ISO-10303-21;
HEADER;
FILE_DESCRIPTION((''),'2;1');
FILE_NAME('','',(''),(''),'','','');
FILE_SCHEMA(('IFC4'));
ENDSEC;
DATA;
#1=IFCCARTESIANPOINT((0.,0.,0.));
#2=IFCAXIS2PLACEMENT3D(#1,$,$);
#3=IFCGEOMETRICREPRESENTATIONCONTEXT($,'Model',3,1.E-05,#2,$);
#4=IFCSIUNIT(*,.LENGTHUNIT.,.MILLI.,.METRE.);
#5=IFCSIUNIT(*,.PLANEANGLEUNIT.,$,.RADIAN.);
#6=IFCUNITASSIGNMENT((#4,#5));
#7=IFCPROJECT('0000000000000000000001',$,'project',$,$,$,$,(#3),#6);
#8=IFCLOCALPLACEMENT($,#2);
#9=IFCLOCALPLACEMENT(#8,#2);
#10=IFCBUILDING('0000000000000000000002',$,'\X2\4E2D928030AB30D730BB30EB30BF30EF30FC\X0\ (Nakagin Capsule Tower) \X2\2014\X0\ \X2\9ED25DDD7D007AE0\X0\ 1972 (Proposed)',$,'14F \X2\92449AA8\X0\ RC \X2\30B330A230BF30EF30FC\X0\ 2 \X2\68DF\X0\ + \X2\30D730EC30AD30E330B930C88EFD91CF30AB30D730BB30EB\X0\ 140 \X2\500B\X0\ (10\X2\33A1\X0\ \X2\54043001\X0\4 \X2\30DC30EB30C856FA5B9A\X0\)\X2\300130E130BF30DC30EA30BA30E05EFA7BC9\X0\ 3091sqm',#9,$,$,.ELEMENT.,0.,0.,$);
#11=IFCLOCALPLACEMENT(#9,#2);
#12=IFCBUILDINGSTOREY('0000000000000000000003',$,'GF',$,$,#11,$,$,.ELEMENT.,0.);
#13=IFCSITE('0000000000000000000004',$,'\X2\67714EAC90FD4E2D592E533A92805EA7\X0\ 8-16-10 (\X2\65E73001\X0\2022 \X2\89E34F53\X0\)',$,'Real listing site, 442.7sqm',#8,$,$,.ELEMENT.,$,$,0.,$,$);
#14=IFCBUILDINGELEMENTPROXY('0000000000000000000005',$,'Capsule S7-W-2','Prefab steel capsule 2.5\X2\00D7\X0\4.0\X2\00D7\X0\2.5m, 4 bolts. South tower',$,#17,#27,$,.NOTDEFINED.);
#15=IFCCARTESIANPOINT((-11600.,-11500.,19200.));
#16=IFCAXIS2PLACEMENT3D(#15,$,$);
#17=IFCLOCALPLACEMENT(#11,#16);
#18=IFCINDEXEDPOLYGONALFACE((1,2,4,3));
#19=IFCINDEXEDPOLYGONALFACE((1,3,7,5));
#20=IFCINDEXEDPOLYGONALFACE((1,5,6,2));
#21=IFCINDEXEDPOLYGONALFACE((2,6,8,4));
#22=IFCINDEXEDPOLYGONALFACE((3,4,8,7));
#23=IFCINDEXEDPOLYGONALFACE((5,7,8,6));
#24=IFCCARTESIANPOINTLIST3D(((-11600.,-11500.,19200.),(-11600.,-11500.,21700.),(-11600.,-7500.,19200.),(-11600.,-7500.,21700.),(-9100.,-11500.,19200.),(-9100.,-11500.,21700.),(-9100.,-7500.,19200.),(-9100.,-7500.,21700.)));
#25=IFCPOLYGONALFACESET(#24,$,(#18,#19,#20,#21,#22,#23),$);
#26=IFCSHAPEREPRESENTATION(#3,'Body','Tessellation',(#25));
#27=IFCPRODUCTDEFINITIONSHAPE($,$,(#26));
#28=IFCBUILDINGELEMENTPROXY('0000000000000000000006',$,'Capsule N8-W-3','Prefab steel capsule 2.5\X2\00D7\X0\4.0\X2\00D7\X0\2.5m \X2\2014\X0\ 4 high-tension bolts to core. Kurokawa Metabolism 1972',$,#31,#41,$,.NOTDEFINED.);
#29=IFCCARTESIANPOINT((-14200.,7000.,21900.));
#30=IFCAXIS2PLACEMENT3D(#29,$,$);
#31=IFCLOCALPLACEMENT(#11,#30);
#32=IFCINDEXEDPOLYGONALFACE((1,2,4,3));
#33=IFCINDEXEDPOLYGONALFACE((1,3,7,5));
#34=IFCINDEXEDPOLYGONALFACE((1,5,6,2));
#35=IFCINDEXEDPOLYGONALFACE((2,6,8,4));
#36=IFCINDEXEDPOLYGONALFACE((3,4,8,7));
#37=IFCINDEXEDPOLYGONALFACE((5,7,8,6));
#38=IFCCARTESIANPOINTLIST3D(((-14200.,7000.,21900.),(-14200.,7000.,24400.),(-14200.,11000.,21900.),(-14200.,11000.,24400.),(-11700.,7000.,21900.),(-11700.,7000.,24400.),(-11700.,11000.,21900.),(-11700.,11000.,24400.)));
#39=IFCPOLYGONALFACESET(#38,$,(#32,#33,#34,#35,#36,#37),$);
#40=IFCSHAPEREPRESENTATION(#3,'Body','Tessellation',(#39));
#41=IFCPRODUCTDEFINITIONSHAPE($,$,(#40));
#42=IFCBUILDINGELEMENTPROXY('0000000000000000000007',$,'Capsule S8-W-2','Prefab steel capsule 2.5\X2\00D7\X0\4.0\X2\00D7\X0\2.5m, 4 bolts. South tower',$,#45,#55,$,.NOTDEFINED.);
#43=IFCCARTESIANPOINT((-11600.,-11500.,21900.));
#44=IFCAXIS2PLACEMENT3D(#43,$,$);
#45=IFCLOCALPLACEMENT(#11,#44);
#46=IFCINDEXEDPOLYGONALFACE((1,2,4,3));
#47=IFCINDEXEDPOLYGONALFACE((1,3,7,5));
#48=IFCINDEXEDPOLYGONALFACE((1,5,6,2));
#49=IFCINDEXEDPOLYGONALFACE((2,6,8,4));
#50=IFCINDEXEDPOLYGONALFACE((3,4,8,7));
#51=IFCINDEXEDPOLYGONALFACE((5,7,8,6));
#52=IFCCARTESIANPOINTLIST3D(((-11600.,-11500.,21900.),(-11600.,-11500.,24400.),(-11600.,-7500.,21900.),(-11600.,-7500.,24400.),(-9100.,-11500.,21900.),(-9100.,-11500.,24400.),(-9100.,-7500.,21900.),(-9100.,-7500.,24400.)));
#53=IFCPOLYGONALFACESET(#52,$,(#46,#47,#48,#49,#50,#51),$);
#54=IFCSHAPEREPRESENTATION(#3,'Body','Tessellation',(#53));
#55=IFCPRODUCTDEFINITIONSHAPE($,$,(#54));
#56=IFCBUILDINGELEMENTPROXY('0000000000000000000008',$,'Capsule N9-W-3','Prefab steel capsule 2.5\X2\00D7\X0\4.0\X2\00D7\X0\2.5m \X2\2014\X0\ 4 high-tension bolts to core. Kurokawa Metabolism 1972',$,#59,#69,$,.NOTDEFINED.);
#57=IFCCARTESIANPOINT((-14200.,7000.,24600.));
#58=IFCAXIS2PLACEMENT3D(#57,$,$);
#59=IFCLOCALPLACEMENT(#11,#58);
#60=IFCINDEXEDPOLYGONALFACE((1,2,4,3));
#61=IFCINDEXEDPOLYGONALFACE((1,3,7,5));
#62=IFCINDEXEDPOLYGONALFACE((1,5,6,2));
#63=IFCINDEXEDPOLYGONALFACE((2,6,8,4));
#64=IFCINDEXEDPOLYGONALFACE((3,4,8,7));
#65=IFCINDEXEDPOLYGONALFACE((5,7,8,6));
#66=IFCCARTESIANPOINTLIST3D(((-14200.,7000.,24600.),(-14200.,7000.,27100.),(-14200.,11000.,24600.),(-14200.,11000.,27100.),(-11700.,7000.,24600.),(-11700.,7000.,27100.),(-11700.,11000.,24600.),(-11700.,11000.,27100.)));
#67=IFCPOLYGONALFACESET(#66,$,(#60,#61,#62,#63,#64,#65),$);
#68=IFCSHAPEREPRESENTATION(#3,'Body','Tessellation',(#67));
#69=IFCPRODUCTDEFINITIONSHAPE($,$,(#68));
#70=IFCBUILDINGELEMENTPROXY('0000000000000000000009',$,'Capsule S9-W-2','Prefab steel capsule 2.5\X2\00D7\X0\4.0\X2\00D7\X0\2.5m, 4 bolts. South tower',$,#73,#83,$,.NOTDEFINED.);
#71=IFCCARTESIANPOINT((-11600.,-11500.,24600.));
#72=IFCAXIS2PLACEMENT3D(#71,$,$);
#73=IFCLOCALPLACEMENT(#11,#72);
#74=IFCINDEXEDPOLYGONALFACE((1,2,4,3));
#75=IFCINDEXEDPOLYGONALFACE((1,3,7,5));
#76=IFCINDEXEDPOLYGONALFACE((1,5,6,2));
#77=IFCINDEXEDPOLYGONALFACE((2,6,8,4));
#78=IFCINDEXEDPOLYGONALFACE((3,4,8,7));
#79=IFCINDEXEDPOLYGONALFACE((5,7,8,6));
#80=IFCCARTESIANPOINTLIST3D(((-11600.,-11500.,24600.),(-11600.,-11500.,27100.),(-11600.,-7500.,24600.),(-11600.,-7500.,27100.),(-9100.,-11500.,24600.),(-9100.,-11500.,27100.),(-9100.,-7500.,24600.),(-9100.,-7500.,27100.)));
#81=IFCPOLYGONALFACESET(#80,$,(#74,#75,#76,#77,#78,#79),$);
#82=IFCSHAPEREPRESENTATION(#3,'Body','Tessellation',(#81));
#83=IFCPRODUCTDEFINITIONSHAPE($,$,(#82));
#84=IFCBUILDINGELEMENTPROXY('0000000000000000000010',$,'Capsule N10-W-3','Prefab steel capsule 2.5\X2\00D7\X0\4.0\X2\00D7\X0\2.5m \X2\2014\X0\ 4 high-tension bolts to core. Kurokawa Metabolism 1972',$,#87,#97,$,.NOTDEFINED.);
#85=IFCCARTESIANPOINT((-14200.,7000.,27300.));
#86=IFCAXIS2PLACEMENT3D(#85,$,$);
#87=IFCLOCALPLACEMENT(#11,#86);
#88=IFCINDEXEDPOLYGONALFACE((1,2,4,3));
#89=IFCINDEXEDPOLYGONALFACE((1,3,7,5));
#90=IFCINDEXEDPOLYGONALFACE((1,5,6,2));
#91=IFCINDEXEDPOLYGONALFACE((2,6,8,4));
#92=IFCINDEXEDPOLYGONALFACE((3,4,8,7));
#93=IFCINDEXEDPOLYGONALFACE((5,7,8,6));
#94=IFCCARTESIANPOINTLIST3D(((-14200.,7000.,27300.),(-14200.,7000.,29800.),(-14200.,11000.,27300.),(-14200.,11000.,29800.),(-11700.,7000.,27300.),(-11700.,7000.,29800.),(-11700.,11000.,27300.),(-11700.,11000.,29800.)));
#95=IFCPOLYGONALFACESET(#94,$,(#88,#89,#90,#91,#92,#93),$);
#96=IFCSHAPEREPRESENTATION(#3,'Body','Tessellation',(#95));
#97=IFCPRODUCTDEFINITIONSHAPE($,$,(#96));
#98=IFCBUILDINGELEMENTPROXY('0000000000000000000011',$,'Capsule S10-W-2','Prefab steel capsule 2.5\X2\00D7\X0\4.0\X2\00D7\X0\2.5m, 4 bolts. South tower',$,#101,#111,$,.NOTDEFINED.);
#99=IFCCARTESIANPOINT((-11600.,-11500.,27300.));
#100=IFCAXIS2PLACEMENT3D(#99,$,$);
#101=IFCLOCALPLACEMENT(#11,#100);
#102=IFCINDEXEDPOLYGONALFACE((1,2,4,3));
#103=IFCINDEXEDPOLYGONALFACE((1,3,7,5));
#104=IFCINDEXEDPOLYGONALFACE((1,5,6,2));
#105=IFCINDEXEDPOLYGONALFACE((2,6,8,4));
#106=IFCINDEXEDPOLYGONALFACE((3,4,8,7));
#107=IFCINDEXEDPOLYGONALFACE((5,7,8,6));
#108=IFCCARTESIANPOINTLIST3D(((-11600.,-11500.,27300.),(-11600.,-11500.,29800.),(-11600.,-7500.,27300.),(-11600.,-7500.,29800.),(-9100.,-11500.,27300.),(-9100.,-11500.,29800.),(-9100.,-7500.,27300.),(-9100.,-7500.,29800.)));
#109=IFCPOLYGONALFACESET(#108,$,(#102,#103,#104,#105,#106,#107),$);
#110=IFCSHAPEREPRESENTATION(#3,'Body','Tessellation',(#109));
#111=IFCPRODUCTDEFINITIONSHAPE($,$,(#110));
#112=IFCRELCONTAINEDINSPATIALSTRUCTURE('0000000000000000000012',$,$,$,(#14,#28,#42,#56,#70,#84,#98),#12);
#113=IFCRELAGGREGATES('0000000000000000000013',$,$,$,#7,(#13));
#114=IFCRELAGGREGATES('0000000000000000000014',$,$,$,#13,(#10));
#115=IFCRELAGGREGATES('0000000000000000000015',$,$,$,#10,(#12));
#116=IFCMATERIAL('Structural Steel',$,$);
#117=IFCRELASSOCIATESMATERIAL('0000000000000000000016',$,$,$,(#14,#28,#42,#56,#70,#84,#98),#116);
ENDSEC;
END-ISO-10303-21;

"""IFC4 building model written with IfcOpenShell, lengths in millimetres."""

from ifc_helpers import new_model, si_unit, frame, frame_2d, origin, place, context, project, spatial, rectangle, extrude, material, element, save


model = new_model("IFC4")

# Units and contexts
model_context = context("Model", 3, precision=1e-05, world=origin())
ifc_project = project(units=[si_unit("LENGTHUNIT", "METRE", prefix="MILLI"), si_unit("PLANEANGLEUNIT", "RADIAN")], contexts=[model_context])

# Site, building, storey
site_placement = place(None, origin())
site = spatial("IfcSite", under=ifc_project, at=site_placement, Name="東京都中央区銀座 8-16-10 (旧、2022 解体)", ObjectType="Real listing site, 442.7sqm", CompositionType="ELEMENT", RefElevation=0.0)
building_placement = place(site_placement, origin())
building = spatial("IfcBuilding", under=site, at=building_placement, Name="中銀カプセルタワー (Nakagin Capsule Tower) — 黒川紀章 1972 (Proposed)", ObjectType="14F 鉄骨 RC コアタワー 2 棟 + プレキャスト軽量カプセル 140 個 (10㎡ 各、4 ボルト固定)、メタボリズム建築 3091sqm", CompositionType="ELEMENT", ElevationOfRefHeight=0.0, ElevationOfTerrain=0.0)
storey_placement = place(building_placement, origin())
storey = spatial("IfcBuildingStorey", under=building, at=storey_placement, Name="GF", CompositionType="ELEMENT", Elevation=0.0)

# Shared definitions
ifc_material_1 = material(Name="Structural Steel")

# Building element proxies
proxy_1_placement = place(storey_placement, frame((-11600.0, -11500.0, 19200.0)))
element("IfcBuildingElementProxy", 1, at=proxy_1_placement, inside=storey, material=ifc_material_1, Name="Capsule S7-W-2", Description="Prefab steel capsule 2.5×4.0×2.5m, 4 bolts. South tower", PredefinedType="NOTDEFINED", context=model_context, shape_type="SweptSolid", body=[
    extrude(rectangle(XDim=2500.0, YDim=4000.0, at=frame_2d((1250.0, 2000.0))), frame((-11600.0, -11500.0, 19200.0)), (0.0, 0.0, 1.0), 2500.0),
])
proxy_2_placement = place(storey_placement, frame((-14200.0, 7000.0, 21900.0)))
element("IfcBuildingElementProxy", 2, at=proxy_2_placement, inside=storey, material=ifc_material_1, Name="Capsule N8-W-3", Description="Prefab steel capsule 2.5×4.0×2.5m — 4 high-tension bolts to core. Kurokawa Metabolism 1972", PredefinedType="NOTDEFINED", context=model_context, shape_type="SweptSolid", body=[
    extrude(rectangle(XDim=2500.0, YDim=4000.0, at=frame_2d((1250.0, 2000.0))), frame((-14200.0, 7000.0, 21900.0)), (0.0, 0.0, 1.0), 2500.0),
])
proxy_3_placement = place(storey_placement, frame((-11600.0, -11500.0, 21900.0)))
element("IfcBuildingElementProxy", 3, at=proxy_3_placement, inside=storey, material=ifc_material_1, Name="Capsule S8-W-2", Description="Prefab steel capsule 2.5×4.0×2.5m, 4 bolts. South tower", PredefinedType="NOTDEFINED", context=model_context, shape_type="SweptSolid", body=[
    extrude(rectangle(XDim=2500.0, YDim=4000.0, at=frame_2d((1250.0, 2000.0))), frame((-11600.0, -11500.0, 21900.0)), (0.0, 0.0, 1.0), 2500.0),
])
proxy_4_placement = place(storey_placement, frame((-14200.0, 7000.0, 24600.0)))
element("IfcBuildingElementProxy", 4, at=proxy_4_placement, inside=storey, material=ifc_material_1, Name="Capsule N9-W-3", Description="Prefab steel capsule 2.5×4.0×2.5m — 4 high-tension bolts to core. Kurokawa Metabolism 1972", PredefinedType="NOTDEFINED", context=model_context, shape_type="SweptSolid", body=[
    extrude(rectangle(XDim=2500.0, YDim=4000.0, at=frame_2d((1250.0, 2000.0))), frame((-14200.0, 7000.0, 24600.0)), (0.0, 0.0, 1.0), 2500.0),
])
proxy_5_placement = place(storey_placement, frame((-11600.0, -11500.0, 24600.0)))
element("IfcBuildingElementProxy", 5, at=proxy_5_placement, inside=storey, material=ifc_material_1, Name="Capsule S9-W-2", Description="Prefab steel capsule 2.5×4.0×2.5m, 4 bolts. South tower", PredefinedType="NOTDEFINED", context=model_context, shape_type="SweptSolid", body=[
    extrude(rectangle(XDim=2500.0, YDim=4000.0, at=frame_2d((1250.0, 2000.0))), frame((-11600.0, -11500.0, 24600.0)), (0.0, 0.0, 1.0), 2500.0),
])
proxy_6_placement = place(storey_placement, frame((-14200.0, 7000.0, 27300.0)))
element("IfcBuildingElementProxy", 6, at=proxy_6_placement, inside=storey, material=ifc_material_1, Name="Capsule N10-W-3", Description="Prefab steel capsule 2.5×4.0×2.5m — 4 high-tension bolts to core. Kurokawa Metabolism 1972", PredefinedType="NOTDEFINED", context=model_context, shape_type="SweptSolid", body=[
    extrude(rectangle(XDim=2500.0, YDim=4000.0, at=frame_2d((1250.0, 2000.0))), frame((-14200.0, 7000.0, 27300.0)), (0.0, 0.0, 1.0), 2500.0),
])
proxy_7_placement = place(storey_placement, frame((-11600.0, -11500.0, 27300.0)))
element("IfcBuildingElementProxy", 7, at=proxy_7_placement, inside=storey, material=ifc_material_1, Name="Capsule S10-W-2", Description="Prefab steel capsule 2.5×4.0×2.5m, 4 bolts. South tower", PredefinedType="NOTDEFINED", context=model_context, shape_type="SweptSolid", body=[
    extrude(rectangle(XDim=2500.0, YDim=4000.0, at=frame_2d((1250.0, 2000.0))), frame((-11600.0, -11500.0, 27300.0)), (0.0, 0.0, 1.0), 2500.0),
])

save(model, "model.ifc")
